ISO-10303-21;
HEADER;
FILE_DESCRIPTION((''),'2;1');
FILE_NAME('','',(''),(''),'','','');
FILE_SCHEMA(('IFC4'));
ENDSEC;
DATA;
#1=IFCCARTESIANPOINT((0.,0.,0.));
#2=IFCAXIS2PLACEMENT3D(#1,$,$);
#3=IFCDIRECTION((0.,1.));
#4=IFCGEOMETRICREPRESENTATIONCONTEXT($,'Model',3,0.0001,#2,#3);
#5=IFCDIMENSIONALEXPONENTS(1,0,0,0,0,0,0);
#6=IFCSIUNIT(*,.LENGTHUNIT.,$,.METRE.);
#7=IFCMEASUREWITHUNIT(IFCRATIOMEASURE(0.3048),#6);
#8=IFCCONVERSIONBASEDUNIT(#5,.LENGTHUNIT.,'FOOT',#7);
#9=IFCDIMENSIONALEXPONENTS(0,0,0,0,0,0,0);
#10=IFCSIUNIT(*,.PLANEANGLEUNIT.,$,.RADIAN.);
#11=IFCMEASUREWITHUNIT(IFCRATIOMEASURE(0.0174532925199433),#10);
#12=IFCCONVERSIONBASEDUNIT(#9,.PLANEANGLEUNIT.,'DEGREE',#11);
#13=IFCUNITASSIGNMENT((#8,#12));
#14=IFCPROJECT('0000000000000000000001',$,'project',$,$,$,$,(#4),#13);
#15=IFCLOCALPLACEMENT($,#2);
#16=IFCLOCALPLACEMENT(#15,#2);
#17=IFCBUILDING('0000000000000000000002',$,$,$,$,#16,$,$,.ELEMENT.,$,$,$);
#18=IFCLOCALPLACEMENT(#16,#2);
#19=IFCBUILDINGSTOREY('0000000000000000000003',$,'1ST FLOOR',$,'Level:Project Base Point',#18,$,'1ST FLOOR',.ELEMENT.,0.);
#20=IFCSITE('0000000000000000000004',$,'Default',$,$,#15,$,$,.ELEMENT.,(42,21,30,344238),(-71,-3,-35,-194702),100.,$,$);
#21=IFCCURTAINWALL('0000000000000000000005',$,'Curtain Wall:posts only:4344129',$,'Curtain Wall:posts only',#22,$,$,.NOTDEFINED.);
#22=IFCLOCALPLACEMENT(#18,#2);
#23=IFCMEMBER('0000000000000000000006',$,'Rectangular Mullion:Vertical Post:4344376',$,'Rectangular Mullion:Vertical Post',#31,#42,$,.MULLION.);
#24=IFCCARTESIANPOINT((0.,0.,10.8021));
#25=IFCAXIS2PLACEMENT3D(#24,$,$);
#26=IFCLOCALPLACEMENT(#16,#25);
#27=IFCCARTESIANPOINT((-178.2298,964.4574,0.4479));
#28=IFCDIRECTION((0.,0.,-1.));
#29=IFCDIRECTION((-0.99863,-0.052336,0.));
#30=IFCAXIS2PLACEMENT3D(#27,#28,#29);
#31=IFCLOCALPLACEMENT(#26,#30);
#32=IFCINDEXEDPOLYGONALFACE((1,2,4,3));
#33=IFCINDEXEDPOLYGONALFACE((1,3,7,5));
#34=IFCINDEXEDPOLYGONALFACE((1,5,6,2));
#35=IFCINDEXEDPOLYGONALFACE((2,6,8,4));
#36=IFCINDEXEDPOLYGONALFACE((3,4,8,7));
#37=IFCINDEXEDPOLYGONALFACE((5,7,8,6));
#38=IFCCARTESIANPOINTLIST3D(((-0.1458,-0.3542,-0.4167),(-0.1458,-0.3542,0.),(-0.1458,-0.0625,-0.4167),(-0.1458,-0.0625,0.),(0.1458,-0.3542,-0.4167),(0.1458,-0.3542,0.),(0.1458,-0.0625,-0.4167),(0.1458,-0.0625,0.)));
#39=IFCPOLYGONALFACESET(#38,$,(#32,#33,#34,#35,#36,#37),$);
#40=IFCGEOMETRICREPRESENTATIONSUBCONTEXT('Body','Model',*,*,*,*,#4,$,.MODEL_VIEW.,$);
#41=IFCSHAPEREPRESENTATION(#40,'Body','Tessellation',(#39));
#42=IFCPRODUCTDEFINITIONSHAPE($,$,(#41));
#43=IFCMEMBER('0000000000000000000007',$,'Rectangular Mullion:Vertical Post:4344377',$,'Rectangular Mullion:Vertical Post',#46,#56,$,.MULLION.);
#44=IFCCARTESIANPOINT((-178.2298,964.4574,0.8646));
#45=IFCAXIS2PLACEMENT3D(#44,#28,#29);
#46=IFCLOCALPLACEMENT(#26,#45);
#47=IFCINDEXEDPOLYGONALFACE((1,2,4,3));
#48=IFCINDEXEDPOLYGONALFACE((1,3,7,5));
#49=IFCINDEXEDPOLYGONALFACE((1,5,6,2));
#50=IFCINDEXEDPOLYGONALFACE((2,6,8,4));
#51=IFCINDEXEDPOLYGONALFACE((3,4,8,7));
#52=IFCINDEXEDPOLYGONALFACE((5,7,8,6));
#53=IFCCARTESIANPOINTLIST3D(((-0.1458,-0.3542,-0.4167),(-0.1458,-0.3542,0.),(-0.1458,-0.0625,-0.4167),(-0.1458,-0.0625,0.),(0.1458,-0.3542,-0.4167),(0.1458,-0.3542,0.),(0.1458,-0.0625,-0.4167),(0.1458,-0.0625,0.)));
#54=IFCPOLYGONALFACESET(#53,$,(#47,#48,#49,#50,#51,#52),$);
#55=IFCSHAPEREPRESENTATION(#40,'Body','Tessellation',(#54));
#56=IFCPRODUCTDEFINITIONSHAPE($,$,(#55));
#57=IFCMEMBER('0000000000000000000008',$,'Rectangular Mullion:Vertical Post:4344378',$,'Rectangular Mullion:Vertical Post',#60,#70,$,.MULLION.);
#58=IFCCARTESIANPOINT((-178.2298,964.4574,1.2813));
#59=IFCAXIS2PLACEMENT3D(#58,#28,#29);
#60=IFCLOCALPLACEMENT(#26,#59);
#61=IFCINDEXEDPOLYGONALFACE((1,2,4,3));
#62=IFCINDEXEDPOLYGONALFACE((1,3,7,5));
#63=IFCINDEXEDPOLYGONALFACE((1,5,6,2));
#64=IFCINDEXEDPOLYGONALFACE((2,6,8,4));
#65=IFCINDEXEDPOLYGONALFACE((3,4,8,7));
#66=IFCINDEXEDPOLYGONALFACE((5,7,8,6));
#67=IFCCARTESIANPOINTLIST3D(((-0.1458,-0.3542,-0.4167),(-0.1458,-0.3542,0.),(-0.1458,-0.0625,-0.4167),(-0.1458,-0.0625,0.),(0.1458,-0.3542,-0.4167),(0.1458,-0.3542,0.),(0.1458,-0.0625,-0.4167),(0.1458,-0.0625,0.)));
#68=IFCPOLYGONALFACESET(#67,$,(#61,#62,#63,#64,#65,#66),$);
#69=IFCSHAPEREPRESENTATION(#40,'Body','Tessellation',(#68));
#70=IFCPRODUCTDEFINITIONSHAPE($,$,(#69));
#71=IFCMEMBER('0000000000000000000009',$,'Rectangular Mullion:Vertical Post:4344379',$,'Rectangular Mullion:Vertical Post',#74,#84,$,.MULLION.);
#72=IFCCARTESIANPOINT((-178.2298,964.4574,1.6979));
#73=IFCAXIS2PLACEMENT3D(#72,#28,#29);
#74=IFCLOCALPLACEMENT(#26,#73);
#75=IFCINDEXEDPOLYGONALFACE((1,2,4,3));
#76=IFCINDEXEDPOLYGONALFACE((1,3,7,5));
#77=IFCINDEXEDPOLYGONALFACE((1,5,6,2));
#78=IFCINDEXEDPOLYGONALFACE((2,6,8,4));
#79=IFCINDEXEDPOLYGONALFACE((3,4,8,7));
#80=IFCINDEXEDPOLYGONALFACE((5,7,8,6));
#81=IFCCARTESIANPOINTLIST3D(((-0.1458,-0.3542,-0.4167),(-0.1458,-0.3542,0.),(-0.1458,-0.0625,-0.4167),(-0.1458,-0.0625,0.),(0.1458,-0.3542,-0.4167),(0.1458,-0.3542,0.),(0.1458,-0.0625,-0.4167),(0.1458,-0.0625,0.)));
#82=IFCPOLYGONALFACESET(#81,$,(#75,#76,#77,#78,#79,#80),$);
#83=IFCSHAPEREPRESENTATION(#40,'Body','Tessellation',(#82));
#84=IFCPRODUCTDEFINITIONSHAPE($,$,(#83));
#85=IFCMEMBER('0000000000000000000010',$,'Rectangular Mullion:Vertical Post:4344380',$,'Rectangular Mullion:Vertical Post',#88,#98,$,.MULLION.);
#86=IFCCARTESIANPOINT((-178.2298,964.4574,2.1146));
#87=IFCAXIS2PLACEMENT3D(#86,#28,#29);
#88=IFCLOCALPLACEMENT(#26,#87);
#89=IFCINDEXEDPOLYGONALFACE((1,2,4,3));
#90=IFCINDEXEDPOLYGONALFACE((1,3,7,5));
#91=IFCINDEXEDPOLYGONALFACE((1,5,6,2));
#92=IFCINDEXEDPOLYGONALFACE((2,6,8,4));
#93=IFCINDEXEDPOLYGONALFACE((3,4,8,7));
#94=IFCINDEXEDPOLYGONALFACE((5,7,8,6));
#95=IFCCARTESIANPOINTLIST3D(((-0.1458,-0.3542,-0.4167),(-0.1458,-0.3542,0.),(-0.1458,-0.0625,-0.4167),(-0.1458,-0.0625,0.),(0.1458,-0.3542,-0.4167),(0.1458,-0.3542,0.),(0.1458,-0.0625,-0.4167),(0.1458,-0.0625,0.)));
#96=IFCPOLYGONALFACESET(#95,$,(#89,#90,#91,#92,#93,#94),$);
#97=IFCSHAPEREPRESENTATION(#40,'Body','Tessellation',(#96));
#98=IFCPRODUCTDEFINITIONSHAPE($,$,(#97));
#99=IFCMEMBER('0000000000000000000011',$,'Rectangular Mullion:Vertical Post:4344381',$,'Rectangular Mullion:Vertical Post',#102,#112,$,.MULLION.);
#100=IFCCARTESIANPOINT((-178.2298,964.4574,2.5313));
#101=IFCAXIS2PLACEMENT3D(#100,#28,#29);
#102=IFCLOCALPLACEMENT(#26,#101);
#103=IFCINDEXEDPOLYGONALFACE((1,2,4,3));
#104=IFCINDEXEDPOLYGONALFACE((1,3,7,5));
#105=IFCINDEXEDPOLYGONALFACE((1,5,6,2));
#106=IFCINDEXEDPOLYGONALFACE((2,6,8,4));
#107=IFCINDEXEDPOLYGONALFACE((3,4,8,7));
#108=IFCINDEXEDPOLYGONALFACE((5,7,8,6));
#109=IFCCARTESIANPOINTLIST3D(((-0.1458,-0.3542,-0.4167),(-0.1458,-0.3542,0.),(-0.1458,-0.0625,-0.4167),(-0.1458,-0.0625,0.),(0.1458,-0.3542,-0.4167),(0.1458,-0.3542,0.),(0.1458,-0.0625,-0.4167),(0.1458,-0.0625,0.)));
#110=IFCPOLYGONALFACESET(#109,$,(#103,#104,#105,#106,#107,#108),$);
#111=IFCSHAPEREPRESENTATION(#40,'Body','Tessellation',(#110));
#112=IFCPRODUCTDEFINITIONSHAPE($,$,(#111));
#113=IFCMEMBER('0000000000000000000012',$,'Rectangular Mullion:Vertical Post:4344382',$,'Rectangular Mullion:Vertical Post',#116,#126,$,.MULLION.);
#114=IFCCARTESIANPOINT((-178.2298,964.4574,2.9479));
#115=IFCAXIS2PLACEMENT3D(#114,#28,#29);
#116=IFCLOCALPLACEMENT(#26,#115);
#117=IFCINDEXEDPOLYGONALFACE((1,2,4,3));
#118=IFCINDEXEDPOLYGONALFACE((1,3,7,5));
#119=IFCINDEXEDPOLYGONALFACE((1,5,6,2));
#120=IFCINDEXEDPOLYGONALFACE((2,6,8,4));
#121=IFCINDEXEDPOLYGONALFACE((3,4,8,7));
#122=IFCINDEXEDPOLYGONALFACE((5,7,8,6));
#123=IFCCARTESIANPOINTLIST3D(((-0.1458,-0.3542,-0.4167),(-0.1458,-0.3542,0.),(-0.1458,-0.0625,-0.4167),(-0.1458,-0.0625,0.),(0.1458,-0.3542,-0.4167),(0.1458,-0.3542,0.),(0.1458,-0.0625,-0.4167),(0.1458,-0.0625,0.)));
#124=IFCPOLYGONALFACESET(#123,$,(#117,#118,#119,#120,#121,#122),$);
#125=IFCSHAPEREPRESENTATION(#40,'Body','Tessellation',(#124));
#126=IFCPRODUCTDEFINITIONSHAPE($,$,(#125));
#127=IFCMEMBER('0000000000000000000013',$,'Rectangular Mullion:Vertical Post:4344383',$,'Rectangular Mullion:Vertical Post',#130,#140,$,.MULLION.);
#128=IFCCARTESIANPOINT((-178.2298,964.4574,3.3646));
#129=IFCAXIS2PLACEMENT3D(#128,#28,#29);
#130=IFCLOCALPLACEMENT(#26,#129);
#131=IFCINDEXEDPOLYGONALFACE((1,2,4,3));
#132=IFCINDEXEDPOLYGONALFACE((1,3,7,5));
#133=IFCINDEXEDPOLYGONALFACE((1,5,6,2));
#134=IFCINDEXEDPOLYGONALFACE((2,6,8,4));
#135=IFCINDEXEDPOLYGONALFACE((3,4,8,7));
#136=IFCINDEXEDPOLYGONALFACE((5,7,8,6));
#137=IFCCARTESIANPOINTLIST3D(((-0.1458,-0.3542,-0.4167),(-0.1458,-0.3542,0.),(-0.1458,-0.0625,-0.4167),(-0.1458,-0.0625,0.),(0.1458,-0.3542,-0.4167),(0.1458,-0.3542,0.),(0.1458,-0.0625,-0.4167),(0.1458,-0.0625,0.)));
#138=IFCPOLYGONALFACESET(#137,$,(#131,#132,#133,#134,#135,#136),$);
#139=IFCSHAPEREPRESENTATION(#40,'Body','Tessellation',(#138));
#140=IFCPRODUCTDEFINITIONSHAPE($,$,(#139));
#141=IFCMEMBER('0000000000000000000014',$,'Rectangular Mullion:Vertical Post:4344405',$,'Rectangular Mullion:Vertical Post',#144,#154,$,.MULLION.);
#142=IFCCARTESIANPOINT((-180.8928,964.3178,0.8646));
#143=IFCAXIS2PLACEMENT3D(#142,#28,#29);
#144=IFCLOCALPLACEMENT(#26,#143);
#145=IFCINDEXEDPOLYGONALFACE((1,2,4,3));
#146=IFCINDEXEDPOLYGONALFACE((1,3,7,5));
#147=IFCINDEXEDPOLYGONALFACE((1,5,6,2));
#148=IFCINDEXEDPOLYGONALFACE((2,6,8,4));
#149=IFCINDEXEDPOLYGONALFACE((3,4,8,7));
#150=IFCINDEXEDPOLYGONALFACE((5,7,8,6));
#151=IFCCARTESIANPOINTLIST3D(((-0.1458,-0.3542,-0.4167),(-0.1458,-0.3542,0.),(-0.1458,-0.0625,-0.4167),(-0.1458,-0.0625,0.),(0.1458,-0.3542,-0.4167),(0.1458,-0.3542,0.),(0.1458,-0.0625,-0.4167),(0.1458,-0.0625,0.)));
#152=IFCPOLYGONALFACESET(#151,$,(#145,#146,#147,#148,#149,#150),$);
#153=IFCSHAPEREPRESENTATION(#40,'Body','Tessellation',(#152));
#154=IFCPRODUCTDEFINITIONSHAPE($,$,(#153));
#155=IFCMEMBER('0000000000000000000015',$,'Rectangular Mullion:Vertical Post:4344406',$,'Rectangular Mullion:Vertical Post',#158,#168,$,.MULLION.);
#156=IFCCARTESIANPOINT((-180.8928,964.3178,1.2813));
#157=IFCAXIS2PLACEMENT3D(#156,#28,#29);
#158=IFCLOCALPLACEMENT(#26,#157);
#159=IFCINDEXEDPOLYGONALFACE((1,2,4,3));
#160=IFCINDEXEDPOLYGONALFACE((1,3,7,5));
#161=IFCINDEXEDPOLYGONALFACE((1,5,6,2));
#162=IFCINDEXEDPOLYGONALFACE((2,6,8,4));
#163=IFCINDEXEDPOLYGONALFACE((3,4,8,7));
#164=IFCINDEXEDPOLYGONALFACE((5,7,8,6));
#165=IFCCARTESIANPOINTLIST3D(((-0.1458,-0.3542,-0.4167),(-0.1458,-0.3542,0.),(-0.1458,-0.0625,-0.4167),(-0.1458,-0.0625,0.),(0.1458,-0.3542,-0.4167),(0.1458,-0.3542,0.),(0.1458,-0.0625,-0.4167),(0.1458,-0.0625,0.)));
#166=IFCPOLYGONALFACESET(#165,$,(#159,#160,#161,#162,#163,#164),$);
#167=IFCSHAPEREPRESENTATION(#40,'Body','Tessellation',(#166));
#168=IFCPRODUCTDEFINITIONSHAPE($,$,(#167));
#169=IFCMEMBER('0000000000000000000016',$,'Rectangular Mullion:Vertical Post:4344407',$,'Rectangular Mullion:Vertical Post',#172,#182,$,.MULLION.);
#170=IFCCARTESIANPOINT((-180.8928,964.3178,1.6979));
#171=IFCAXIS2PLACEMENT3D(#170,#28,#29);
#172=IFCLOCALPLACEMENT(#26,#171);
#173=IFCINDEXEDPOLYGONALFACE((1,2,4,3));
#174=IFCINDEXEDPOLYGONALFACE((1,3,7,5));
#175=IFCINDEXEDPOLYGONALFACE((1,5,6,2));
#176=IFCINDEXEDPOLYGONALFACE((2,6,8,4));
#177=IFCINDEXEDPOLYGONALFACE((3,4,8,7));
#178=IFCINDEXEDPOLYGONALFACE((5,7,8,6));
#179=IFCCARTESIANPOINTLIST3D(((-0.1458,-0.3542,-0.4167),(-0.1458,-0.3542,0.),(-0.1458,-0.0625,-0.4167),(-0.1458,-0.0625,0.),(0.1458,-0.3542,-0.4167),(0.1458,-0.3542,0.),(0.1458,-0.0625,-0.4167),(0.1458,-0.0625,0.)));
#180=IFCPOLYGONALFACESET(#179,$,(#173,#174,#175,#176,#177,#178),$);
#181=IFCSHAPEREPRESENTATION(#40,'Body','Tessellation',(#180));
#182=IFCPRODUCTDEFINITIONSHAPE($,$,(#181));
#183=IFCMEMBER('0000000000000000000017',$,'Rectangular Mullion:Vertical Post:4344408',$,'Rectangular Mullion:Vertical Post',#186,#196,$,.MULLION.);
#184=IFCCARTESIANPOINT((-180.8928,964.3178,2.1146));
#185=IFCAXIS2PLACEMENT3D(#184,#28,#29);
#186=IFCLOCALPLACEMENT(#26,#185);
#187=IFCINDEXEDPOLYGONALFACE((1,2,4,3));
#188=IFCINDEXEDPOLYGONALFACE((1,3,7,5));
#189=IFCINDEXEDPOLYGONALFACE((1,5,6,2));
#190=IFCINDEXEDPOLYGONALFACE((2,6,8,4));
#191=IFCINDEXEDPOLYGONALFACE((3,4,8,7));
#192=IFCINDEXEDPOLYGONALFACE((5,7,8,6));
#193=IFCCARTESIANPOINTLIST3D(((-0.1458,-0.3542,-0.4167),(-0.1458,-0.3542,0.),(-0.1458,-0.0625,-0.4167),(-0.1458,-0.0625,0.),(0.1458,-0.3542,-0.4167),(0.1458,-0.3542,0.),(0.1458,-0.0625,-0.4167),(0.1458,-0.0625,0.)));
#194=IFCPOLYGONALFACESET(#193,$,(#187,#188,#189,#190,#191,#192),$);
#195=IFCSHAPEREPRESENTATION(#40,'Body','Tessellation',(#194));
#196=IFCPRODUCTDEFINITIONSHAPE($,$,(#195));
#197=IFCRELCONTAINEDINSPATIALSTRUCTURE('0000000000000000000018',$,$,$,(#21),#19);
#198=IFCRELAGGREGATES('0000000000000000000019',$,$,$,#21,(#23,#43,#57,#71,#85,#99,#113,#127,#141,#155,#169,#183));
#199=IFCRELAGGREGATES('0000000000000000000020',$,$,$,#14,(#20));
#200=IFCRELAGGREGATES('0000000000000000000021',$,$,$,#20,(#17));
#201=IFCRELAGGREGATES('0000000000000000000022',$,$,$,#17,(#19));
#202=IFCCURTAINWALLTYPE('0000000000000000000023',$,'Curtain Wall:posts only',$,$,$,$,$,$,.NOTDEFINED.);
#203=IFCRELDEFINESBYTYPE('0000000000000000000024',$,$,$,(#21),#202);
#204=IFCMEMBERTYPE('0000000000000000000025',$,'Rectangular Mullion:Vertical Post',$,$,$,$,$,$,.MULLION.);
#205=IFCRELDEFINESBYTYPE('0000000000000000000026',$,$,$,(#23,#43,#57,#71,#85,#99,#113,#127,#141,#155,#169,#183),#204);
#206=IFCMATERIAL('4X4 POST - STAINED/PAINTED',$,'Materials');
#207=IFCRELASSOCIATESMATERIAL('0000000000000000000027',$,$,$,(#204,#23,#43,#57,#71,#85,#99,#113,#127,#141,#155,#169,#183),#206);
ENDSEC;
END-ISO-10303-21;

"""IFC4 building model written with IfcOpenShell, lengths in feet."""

from ifc_helpers import new_model, entity, si_unit, converted_unit, direction, frame, origin, origin_2d_with_axis, place, context, subcontext, project, spatial, rectangle, extrude, source, transform, mapped, material, material_profile, profile_set, profile_usage, type_object, type_shapes, element, aggregate, save


model = new_model("IFC4")

# Units and contexts
model_context = context("Model", 3, precision=0.0001, world=origin(), true_north=direction((0.0, 1.0)))
body_context = subcontext(model_context, "Body", "Model", "MODEL_VIEW")
ifc_project = project(units=[converted_unit("LENGTHUNIT", "FOOT", entity("IfcRatioMeasure", 0.3048), si_unit("LENGTHUNIT", "METRE"), dimensions=[1, 0, 0, 0, 0, 0, 0]), converted_unit("PLANEANGLEUNIT", "DEGREE", entity("IfcRatioMeasure", 0.0174532925199433), si_unit("PLANEANGLEUNIT", "RADIAN"), dimensions=[0, 0, 0, 0, 0, 0, 0])], contexts=[model_context])

# Site, building, storey
site_placement = place(None, origin())
site = spatial("IfcSite", under=ifc_project, at=site_placement, Name="Default", CompositionType="ELEMENT", RefLatitude=(42, 21, 30, 344238), RefLongitude=(-71, -3, -35, -194702), RefElevation=100.0)
building_placement = place(site_placement, origin())
building = spatial("IfcBuilding", under=site, at=building_placement, CompositionType="ELEMENT")
storey_placement = place(building_placement, origin())
storey = spatial("IfcBuildingStorey", under=building, at=storey_placement, Name="1ST FLOOR", ObjectType="Level:Project Base Point", LongName="1ST FLOOR", CompositionType="ELEMENT", Elevation=0.0)

# Curtain wall, members
curtain_wall_type_1 = type_object("IfcCurtainWallType", Name="Curtain Wall:posts only", PredefinedType="NOTDEFINED")
curtain_wall_1_placement = place(storey_placement, origin())
curtain_wall_1 = element("IfcCurtainWall", 1, at=curtain_wall_1_placement, inside=storey, type_object=curtain_wall_type_1, Name="Curtain Wall:posts only:4344129", ObjectType="Curtain Wall:posts only", PredefinedType="NOTDEFINED")
ifc_material_1 = material(Name="4X4 POST - STAINED/PAINTED", Category="Materials")
ifc_material_profile_1 = material_profile(ifc_material_1, rectangle(XDim=0.2917, YDim=0.2917, at=origin_2d_with_axis()), Name="Vertical Post")
ifc_profile_set_1 = profile_set([ifc_material_profile_1], Name="Vertical Post")
ifc_profile_usage_1 = profile_usage(ifc_profile_set_1)
member_type_1 = type_object("IfcMemberType", Name="Rectangular Mullion:Vertical Post", PredefinedType="MULLION", material=ifc_profile_set_1)
shared_shape_1 = source(origin(), body_context, "Body", "SweptSolid", [
    extrude(rectangle(XDim=0.2917, YDim=0.2917, at=origin_2d_with_axis()), frame((0.0, -0.2083, -0.4167), z_axis=(0.0, 0.0, 1.0), x_axis=(0.0, -1.0, 0.0)), (0.0, 0.0, 1.0), 0.4167),
])
type_shapes(member_type_1, [shared_shape_1])
placement = place(building_placement, frame((0.0, 0.0, 10.8021)))
member_1_placement = place(placement, frame((-178.2298, 964.4574, 0.4479), z_axis=(0.0, 0.0, -1.0), x_axis=(-0.99863, -0.052336, 0.0)))
member_1 = element("IfcMember", 2, at=member_1_placement, type_object=member_type_1, material=ifc_profile_usage_1, Name="Rectangular Mullion:Vertical Post:4344376", ObjectType="Rectangular Mullion:Vertical Post", PredefinedType="MULLION", context=body_context, shape_type="MappedRepresentation", body=[
    mapped(shared_shape_1, transform((0.0, 0.0, 0.0), scale=1.0)),
])
ifc_profile_usage_2 = profile_usage(ifc_profile_set_1)
member_2_placement = place(placement, frame((-178.2298, 964.4574, 0.8646), z_axis=(0.0, 0.0, -1.0), x_axis=(-0.99863, -0.052336, 0.0)))
member_2 = element("IfcMember", 3, at=member_2_placement, type_object=member_type_1, material=ifc_profile_usage_2, Name="Rectangular Mullion:Vertical Post:4344377", ObjectType="Rectangular Mullion:Vertical Post", PredefinedType="MULLION", context=body_context, shape_type="MappedRepresentation", body=[
    mapped(shared_shape_1, transform((0.0, 0.0, 0.0), scale=1.0)),
])
ifc_profile_usage_3 = profile_usage(ifc_profile_set_1)
member_3_placement = place(placement, frame((-178.2298, 964.4574, 1.2813), z_axis=(0.0, 0.0, -1.0), x_axis=(-0.99863, -0.052336, 0.0)))
member_3 = element("IfcMember", 4, at=member_3_placement, type_object=member_type_1, material=ifc_profile_usage_3, Name="Rectangular Mullion:Vertical Post:4344378", ObjectType="Rectangular Mullion:Vertical Post", PredefinedType="MULLION", context=body_context, shape_type="MappedRepresentation", body=[
    mapped(shared_shape_1, transform((0.0, 0.0, 0.0), scale=1.0)),
])
ifc_profile_usage_4 = profile_usage(ifc_profile_set_1)
member_4_placement = place(placement, frame((-178.2298, 964.4574, 1.6979), z_axis=(0.0, 0.0, -1.0), x_axis=(-0.99863, -0.052336, 0.0)))
member_4 = element("IfcMember", 5, at=member_4_placement, type_object=member_type_1, material=ifc_profile_usage_4, Name="Rectangular Mullion:Vertical Post:4344379", ObjectType="Rectangular Mullion:Vertical Post", PredefinedType="MULLION", context=body_context, shape_type="MappedRepresentation", body=[
    mapped(shared_shape_1, transform((0.0, 0.0, 0.0), scale=1.0)),
])
ifc_profile_usage_5 = profile_usage(ifc_profile_set_1)
member_5_placement = place(placement, frame((-178.2298, 964.4574, 2.1146), z_axis=(0.0, 0.0, -1.0), x_axis=(-0.99863, -0.052336, 0.0)))
member_5 = element("IfcMember", 6, at=member_5_placement, type_object=member_type_1, material=ifc_profile_usage_5, Name="Rectangular Mullion:Vertical Post:4344380", ObjectType="Rectangular Mullion:Vertical Post", PredefinedType="MULLION", context=body_context, shape_type="MappedRepresentation", body=[
    mapped(shared_shape_1, transform((0.0, 0.0, 0.0), scale=1.0)),
])
ifc_profile_usage_6 = profile_usage(ifc_profile_set_1)
member_6_placement = place(placement, frame((-178.2298, 964.4574, 2.5313), z_axis=(0.0, 0.0, -1.0), x_axis=(-0.99863, -0.052336, 0.0)))
member_6 = element("IfcMember", 7, at=member_6_placement, type_object=member_type_1, material=ifc_profile_usage_6, Name="Rectangular Mullion:Vertical Post:4344381", ObjectType="Rectangular Mullion:Vertical Post", PredefinedType="MULLION", context=body_context, shape_type="MappedRepresentation", body=[
    mapped(shared_shape_1, transform((0.0, 0.0, 0.0), scale=1.0)),
])
ifc_profile_usage_7 = profile_usage(ifc_profile_set_1)
member_7_placement = place(placement, frame((-178.2298, 964.4574, 2.9479), z_axis=(0.0, 0.0, -1.0), x_axis=(-0.99863, -0.052336, 0.0)))
member_7 = element("IfcMember", 8, at=member_7_placement, type_object=member_type_1, material=ifc_profile_usage_7, Name="Rectangular Mullion:Vertical Post:4344382", ObjectType="Rectangular Mullion:Vertical Post", PredefinedType="MULLION", context=body_context, shape_type="MappedRepresentation", body=[
    mapped(shared_shape_1, transform((0.0, 0.0, 0.0), scale=1.0)),
])
ifc_profile_usage_8 = profile_usage(ifc_profile_set_1)
member_8_placement = place(placement, frame((-178.2298, 964.4574, 3.3646), z_axis=(0.0, 0.0, -1.0), x_axis=(-0.99863, -0.052336, 0.0)))
member_8 = element("IfcMember", 9, at=member_8_placement, type_object=member_type_1, material=ifc_profile_usage_8, Name="Rectangular Mullion:Vertical Post:4344383", ObjectType="Rectangular Mullion:Vertical Post", PredefinedType="MULLION", context=body_context, shape_type="MappedRepresentation", body=[
    mapped(shared_shape_1, transform((0.0, 0.0, 0.0), scale=1.0)),
])
ifc_profile_usage_9 = profile_usage(ifc_profile_set_1)
member_9_placement = place(placement, frame((-180.8928, 964.3178, 0.8646), z_axis=(0.0, 0.0, -1.0), x_axis=(-0.99863, -0.052336, 0.0)))
member_9 = element("IfcMember", 10, at=member_9_placement, type_object=member_type_1, material=ifc_profile_usage_9, Name="Rectangular Mullion:Vertical Post:4344405", ObjectType="Rectangular Mullion:Vertical Post", PredefinedType="MULLION", context=body_context, shape_type="MappedRepresentation", body=[
    mapped(shared_shape_1, transform((0.0, 0.0, 0.0), scale=1.0)),
])
ifc_profile_usage_10 = profile_usage(ifc_profile_set_1)
member_10_placement = place(placement, frame((-180.8928, 964.3178, 1.2813), z_axis=(0.0, 0.0, -1.0), x_axis=(-0.99863, -0.052336, 0.0)))
member_10 = element("IfcMember", 11, at=member_10_placement, type_object=member_type_1, material=ifc_profile_usage_10, Name="Rectangular Mullion:Vertical Post:4344406", ObjectType="Rectangular Mullion:Vertical Post", PredefinedType="MULLION", context=body_context, shape_type="MappedRepresentation", body=[
    mapped(shared_shape_1, transform((0.0, 0.0, 0.0), scale=1.0)),
])
ifc_profile_usage_11 = profile_usage(ifc_profile_set_1)
member_11_placement = place(placement, frame((-180.8928, 964.3178, 1.6979), z_axis=(0.0, 0.0, -1.0), x_axis=(-0.99863, -0.052336, 0.0)))
member_11 = element("IfcMember", 12, at=member_11_placement, type_object=member_type_1, material=ifc_profile_usage_11, Name="Rectangular Mullion:Vertical Post:4344407", ObjectType="Rectangular Mullion:Vertical Post", PredefinedType="MULLION", context=body_context, shape_type="MappedRepresentation", body=[
    mapped(shared_shape_1, transform((0.0, 0.0, 0.0), scale=1.0)),
])
ifc_profile_usage_12 = profile_usage(ifc_profile_set_1)
member_12_placement = place(placement, frame((-180.8928, 964.3178, 2.1146), z_axis=(0.0, 0.0, -1.0), x_axis=(-0.99863, -0.052336, 0.0)))
member_12 = element("IfcMember", 13, at=member_12_placement, type_object=member_type_1, material=ifc_profile_usage_12, Name="Rectangular Mullion:Vertical Post:4344408", ObjectType="Rectangular Mullion:Vertical Post", PredefinedType="MULLION", context=body_context, shape_type="MappedRepresentation", body=[
    mapped(shared_shape_1, transform((0.0, 0.0, 0.0), scale=1.0)),
])
aggregate(curtain_wall_1, [member_1, member_2, member_3, member_4, member_5, member_6, member_7, member_8, member_9, member_10, member_11, member_12])

save(model, "model.ifc")
